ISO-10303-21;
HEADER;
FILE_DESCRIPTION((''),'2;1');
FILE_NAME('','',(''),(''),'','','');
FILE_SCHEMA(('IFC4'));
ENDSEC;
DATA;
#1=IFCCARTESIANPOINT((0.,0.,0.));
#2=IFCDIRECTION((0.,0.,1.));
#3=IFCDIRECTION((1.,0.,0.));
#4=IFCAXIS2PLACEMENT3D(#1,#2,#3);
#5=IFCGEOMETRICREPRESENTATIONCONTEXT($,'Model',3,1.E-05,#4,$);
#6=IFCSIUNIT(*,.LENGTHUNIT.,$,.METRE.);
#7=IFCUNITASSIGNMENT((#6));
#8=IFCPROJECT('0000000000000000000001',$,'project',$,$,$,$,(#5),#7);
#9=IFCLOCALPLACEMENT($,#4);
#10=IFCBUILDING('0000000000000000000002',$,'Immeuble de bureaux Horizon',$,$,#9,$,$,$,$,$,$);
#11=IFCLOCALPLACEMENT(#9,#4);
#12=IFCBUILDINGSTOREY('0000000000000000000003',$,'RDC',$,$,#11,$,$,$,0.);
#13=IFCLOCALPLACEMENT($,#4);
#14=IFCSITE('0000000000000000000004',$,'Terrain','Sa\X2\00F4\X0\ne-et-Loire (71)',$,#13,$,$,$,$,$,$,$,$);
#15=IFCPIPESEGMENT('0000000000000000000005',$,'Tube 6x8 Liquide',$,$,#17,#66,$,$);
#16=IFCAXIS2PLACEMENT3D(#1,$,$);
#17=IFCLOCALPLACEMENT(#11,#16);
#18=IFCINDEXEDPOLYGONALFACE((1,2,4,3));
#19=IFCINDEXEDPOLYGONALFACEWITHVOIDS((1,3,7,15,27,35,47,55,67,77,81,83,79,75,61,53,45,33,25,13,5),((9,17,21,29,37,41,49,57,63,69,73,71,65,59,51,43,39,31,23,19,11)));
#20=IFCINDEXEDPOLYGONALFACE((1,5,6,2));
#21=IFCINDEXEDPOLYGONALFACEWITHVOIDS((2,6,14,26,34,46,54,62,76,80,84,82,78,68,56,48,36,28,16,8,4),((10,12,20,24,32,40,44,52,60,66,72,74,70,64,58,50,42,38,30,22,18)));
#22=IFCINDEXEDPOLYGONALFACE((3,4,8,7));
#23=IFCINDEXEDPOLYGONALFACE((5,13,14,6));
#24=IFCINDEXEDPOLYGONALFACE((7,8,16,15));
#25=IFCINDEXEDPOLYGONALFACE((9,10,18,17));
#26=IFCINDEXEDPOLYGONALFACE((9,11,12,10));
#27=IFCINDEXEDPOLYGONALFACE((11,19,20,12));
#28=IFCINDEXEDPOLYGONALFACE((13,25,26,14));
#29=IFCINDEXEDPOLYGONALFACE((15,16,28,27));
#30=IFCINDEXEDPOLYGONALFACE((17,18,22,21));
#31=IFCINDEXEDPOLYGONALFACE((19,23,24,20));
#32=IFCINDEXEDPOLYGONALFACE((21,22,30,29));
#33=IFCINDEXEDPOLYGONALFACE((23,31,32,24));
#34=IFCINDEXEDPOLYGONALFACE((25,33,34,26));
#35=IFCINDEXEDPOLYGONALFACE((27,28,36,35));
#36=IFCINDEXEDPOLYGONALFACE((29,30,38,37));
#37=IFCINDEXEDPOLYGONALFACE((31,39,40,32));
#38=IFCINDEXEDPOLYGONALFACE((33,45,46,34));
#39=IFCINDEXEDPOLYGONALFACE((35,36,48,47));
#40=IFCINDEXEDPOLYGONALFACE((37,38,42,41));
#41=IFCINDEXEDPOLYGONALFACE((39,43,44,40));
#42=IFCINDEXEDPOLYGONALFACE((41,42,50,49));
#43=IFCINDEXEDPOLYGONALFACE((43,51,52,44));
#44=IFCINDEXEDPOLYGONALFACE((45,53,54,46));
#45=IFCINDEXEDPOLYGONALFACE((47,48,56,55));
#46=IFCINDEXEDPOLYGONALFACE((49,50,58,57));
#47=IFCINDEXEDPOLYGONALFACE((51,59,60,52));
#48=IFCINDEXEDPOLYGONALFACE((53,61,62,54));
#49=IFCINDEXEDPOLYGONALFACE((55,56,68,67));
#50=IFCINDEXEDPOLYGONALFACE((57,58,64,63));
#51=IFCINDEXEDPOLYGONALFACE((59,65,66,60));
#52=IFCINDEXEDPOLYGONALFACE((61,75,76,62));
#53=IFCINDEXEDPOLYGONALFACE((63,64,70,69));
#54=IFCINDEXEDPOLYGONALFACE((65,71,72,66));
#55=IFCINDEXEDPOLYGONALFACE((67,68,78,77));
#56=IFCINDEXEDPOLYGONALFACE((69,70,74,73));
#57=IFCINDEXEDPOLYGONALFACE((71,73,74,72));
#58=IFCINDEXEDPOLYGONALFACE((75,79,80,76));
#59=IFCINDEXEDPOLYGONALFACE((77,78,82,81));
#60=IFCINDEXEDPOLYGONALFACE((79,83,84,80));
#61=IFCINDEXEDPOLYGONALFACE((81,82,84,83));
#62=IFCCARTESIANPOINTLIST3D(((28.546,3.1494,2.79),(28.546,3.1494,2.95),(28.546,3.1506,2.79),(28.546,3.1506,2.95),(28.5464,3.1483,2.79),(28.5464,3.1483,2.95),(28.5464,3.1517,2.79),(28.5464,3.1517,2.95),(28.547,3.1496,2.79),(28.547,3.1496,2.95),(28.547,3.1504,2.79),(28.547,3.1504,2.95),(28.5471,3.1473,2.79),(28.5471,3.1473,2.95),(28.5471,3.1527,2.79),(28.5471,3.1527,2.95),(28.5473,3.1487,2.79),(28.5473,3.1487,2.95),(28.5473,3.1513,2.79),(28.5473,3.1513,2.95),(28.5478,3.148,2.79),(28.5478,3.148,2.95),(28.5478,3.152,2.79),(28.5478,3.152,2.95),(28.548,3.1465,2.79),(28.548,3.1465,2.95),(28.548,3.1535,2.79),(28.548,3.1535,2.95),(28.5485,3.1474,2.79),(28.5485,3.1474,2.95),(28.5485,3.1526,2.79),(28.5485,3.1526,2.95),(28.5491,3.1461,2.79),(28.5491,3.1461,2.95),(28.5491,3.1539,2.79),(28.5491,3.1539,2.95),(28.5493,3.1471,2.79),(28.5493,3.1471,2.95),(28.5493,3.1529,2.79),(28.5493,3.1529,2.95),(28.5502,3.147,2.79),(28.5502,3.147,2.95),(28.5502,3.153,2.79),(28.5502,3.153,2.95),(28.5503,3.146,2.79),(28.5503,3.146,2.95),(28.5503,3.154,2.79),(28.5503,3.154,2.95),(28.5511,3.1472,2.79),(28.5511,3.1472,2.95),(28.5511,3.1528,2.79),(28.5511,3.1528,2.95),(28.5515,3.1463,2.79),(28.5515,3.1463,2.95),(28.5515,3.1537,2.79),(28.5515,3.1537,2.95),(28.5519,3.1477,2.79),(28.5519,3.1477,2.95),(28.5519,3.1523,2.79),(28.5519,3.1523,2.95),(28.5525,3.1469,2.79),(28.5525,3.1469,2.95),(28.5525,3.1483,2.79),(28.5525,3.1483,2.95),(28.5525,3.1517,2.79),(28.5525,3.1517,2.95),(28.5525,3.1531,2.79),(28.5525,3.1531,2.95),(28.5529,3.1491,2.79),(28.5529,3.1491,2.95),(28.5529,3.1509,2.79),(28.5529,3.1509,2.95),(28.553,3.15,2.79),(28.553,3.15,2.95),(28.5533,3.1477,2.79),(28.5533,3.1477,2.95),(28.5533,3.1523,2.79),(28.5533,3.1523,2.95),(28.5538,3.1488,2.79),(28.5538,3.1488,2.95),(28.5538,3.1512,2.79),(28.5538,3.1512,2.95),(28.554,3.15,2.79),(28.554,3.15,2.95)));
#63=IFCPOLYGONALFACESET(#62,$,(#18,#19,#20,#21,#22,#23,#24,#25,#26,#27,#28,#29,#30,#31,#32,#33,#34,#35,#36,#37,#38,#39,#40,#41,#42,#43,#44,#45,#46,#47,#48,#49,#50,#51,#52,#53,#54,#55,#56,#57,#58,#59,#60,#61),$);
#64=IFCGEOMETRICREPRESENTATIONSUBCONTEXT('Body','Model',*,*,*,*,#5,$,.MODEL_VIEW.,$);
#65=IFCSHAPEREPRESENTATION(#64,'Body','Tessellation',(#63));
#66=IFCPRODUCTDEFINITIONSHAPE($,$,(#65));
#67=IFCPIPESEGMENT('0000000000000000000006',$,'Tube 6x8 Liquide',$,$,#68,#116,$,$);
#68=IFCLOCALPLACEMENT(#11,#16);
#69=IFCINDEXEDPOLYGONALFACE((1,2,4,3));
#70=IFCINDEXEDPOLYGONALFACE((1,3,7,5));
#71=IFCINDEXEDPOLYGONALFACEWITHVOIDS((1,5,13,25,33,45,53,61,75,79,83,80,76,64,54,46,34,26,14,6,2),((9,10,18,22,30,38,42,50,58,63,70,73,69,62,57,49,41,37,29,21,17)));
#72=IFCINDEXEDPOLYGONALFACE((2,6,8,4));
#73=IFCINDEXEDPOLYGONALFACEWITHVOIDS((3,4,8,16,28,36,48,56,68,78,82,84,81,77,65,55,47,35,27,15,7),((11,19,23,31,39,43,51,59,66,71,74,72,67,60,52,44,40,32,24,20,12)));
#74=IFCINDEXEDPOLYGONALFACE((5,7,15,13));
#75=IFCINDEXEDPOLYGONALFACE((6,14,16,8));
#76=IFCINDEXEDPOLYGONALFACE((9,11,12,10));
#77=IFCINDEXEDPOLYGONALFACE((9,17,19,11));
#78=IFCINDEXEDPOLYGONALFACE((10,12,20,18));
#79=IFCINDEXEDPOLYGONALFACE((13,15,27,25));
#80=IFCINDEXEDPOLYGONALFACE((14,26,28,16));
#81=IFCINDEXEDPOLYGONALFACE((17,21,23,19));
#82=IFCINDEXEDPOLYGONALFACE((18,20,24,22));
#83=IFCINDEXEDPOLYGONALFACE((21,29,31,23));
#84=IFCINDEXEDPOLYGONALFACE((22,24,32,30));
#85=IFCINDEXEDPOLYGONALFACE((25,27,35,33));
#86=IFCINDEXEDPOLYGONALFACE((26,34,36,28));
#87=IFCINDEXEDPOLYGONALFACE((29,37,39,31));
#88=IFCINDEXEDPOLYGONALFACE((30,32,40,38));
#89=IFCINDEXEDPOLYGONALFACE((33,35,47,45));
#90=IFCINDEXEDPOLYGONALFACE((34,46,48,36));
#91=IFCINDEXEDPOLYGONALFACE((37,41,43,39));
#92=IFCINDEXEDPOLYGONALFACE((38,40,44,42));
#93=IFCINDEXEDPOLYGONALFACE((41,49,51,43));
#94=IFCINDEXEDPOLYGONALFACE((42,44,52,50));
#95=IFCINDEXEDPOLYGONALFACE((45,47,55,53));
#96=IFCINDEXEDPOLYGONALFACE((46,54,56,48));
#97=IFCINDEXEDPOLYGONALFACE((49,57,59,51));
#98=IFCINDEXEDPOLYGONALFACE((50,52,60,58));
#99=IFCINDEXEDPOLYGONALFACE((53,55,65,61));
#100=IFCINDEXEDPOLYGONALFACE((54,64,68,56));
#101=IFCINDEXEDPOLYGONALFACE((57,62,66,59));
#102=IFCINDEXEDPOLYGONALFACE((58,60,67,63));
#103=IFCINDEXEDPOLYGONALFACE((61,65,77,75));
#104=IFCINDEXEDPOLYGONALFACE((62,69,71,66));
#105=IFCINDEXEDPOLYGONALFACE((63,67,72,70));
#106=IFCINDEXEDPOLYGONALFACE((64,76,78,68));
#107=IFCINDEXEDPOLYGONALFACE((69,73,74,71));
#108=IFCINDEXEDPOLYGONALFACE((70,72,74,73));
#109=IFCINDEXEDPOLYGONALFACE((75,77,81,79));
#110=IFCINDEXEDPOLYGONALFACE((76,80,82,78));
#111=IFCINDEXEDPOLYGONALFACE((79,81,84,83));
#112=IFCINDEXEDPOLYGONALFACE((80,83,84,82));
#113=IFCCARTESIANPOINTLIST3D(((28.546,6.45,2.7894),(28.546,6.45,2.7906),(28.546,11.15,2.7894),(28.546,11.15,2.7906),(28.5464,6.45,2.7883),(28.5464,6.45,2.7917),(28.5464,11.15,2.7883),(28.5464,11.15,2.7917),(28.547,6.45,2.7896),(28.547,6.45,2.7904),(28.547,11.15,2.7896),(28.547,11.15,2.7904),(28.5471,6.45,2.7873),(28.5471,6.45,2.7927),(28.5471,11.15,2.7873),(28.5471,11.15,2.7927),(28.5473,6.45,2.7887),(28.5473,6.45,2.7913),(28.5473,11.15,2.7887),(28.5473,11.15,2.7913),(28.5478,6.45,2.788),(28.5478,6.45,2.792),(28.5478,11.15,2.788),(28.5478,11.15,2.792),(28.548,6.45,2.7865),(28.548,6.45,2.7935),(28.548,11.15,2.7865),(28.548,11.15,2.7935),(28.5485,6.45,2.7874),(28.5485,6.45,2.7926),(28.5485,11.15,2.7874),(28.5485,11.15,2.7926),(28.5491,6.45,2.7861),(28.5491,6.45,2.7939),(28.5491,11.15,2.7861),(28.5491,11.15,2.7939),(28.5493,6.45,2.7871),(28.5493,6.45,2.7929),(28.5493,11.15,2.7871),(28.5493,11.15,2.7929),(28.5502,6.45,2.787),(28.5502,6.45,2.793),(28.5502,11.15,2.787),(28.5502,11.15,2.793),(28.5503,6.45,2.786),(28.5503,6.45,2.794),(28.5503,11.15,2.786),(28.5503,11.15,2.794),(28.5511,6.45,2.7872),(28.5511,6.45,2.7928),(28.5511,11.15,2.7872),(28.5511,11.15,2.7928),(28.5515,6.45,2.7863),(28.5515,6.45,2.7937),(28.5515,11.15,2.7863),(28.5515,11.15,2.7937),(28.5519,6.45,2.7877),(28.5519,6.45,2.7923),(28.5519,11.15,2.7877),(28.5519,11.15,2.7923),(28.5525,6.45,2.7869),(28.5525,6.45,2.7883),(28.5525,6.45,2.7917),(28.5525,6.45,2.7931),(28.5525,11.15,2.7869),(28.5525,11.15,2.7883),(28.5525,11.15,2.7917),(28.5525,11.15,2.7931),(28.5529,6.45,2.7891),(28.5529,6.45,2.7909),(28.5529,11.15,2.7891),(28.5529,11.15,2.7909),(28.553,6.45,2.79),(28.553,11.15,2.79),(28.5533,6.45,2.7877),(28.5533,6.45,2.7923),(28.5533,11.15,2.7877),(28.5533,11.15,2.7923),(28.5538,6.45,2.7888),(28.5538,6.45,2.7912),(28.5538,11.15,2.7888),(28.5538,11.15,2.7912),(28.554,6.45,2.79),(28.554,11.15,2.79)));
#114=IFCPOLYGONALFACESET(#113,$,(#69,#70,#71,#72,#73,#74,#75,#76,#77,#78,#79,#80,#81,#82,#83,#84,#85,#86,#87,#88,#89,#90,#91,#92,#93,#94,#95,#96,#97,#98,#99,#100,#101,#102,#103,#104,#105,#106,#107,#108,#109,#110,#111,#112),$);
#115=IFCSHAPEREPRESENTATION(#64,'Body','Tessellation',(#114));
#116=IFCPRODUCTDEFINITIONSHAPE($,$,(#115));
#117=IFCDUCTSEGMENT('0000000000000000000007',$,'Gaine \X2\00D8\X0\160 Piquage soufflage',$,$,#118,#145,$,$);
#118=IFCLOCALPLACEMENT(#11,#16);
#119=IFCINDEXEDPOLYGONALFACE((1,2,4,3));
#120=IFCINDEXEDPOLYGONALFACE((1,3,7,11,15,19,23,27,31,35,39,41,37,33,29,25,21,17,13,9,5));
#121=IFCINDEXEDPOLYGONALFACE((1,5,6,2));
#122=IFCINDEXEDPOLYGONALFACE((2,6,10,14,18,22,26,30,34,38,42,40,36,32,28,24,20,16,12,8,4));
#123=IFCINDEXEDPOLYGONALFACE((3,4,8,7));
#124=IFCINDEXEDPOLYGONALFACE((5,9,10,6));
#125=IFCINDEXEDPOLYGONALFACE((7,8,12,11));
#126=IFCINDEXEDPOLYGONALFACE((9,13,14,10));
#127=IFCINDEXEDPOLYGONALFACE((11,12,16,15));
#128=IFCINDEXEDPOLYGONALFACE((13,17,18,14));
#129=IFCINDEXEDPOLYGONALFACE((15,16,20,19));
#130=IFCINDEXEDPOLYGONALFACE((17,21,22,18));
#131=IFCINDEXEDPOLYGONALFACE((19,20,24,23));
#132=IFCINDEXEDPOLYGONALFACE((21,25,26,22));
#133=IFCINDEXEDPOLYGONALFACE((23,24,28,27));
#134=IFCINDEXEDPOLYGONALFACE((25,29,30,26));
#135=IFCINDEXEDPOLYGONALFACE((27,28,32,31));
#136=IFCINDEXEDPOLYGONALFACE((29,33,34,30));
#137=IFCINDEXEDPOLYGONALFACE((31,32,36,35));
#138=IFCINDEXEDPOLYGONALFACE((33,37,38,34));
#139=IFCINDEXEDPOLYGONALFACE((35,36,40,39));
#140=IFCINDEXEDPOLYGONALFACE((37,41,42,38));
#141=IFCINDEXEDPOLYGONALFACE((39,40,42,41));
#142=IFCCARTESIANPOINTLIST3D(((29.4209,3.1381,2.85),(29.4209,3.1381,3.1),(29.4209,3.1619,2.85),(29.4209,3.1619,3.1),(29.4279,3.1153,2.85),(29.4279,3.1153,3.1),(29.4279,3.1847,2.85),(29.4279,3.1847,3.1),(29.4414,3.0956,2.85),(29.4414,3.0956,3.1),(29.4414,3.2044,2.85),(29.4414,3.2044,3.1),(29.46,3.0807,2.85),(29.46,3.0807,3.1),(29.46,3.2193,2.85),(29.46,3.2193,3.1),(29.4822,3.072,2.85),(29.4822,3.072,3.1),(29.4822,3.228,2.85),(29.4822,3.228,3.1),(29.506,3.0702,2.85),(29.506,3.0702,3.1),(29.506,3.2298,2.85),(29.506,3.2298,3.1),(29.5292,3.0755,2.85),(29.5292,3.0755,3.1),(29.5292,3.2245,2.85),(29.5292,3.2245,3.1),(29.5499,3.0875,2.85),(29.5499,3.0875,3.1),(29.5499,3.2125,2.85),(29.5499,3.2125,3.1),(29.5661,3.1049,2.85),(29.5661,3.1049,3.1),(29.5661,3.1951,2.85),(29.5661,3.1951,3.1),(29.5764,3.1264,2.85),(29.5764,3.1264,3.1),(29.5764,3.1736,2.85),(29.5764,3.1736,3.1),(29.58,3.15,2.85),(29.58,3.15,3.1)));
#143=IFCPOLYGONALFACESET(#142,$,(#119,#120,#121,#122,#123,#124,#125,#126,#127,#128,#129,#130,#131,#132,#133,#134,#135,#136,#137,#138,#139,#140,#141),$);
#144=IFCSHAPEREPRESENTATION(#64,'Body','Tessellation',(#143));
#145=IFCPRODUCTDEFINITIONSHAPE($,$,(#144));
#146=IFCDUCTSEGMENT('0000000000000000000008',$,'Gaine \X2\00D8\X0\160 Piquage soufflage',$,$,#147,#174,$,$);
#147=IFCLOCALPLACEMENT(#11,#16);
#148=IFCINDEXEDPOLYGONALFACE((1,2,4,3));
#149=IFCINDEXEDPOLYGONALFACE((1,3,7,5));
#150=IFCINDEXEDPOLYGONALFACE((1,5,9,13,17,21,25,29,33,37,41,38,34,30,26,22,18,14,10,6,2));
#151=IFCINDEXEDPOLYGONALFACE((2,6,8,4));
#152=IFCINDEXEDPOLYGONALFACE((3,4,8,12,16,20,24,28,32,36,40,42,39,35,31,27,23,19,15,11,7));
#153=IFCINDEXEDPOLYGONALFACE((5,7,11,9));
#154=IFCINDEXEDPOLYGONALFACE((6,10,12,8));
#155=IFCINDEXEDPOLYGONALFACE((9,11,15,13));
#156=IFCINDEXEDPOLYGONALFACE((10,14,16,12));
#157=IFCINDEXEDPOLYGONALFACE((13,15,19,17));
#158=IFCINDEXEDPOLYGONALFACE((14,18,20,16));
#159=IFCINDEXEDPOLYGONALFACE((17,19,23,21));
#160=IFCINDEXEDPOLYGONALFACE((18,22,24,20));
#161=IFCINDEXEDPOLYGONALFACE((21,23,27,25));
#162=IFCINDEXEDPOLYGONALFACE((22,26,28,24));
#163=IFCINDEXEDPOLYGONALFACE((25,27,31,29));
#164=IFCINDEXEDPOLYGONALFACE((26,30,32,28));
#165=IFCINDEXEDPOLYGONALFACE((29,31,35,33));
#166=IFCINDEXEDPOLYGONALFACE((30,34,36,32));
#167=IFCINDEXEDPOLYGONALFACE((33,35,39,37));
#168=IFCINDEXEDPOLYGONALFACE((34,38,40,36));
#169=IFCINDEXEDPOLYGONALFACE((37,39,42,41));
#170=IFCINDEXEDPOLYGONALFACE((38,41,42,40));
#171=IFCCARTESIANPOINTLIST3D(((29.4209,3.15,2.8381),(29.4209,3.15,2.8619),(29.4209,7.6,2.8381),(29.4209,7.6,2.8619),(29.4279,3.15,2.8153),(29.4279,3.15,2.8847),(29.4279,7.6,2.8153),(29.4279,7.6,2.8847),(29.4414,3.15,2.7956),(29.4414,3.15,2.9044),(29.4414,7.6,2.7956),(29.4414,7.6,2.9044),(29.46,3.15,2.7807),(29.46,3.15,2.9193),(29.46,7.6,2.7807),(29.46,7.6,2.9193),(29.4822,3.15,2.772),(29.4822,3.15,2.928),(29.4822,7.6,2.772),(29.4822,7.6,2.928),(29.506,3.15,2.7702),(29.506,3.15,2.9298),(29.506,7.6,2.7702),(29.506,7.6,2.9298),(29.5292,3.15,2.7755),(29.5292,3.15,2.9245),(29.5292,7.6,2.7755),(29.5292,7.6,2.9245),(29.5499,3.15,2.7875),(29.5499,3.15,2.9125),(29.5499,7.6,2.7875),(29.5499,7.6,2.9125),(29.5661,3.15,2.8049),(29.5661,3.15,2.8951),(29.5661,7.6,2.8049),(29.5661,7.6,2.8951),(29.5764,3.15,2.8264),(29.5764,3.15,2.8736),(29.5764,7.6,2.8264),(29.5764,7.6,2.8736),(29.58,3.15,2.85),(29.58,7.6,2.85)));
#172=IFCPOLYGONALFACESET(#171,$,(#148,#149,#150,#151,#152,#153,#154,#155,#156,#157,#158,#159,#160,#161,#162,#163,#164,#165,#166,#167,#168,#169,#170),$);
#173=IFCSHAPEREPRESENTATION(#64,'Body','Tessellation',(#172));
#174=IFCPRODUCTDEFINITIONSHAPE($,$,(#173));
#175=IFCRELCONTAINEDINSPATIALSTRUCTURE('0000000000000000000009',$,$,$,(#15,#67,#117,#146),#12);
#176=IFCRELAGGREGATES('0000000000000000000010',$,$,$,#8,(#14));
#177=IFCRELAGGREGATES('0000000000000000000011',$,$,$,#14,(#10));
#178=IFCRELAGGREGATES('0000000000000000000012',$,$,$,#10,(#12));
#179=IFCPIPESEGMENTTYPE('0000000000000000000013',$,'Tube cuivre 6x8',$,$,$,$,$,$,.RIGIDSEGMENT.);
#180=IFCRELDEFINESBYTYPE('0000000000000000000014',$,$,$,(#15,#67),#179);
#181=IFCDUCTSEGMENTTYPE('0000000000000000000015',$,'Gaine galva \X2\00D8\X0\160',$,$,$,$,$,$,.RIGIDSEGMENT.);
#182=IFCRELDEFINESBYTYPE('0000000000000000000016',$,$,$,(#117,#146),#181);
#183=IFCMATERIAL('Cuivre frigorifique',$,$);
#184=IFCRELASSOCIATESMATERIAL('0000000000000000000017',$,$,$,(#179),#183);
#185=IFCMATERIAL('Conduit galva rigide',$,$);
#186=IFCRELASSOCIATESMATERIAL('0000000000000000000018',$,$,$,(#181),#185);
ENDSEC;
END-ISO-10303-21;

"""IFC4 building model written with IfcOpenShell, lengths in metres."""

from ifc_helpers import new_model, si_unit, frame, origin_with_axes, place, context, subcontext, project, spatial, circle, hollow_circle, extrude, material, type_object, element, save


model = new_model("IFC4")

# Units and contexts
model_context = context("Model", 3, precision=1e-05, world=origin_with_axes())
body_context = subcontext(model_context, "Body", "Model", "MODEL_VIEW")
ifc_project = project(units=[si_unit("LENGTHUNIT", "METRE")], contexts=[model_context])

# Site, building, storey
site_placement = place(None, origin_with_axes())
site = spatial("IfcSite", under=ifc_project, at=site_placement, Name="Terrain", Description="Saône-et-Loire (71)")
building_placement = place(None, origin_with_axes())
building = spatial("IfcBuilding", under=site, at=building_placement, Name="Immeuble de bureaux Horizon")
storey_placement = place(building_placement, origin_with_axes())
storey = spatial("IfcBuildingStorey", under=building, at=storey_placement, Name="RDC", Elevation=0.0)

# Shared definitions
ifc_material_1 = material(Name="Cuivre frigorifique")

# Pipe segments
pipe_segment_type_1 = type_object("IfcPipeSegmentType", Name="Tube cuivre 6x8", PredefinedType="RIGIDSEGMENT", material=ifc_material_1)
pipe_segment_1_placement = place(storey_placement, frame((28.55, 3.15, 2.79), z_axis=(0.0, 0.0, 1.0), x_axis=(1.0, 0.0, 0.0)))
element("IfcPipeSegment", 1, at=pipe_segment_1_placement, inside=storey, type_object=pipe_segment_type_1, Name="Tube 6x8 Liquide", context=body_context, shape_type="SweptSolid", body=[
    extrude(hollow_circle(Radius=0.004, WallThickness=0.001), origin_with_axes(), (0.0, 0.0, 1.0), 0.16),
])
pipe_segment_2_placement = place(storey_placement, frame((28.55, 6.45, 2.79), z_axis=(0.0, 1.0, 0.0), x_axis=(1.0, 0.0, 0.0)))
element("IfcPipeSegment", 2, at=pipe_segment_2_placement, inside=storey, type_object=pipe_segment_type_1, Name="Tube 6x8 Liquide", context=body_context, shape_type="SweptSolid", body=[
    extrude(hollow_circle(Radius=0.004, WallThickness=0.001), origin_with_axes(), (0.0, 0.0, 1.0), 4.7),
])

# Duct segments
ifc_material_2 = material(Name="Conduit galva rigide")
duct_segment_type_1 = type_object("IfcDuctSegmentType", Name="Gaine galva Ø160", PredefinedType="RIGIDSEGMENT", material=ifc_material_2)
duct_segment_1_placement = place(storey_placement, frame((29.5, 3.15, 3.1), z_axis=(0.0, 0.0, -1.0), x_axis=(1.0, 0.0, 0.0)))
element("IfcDuctSegment", 3, at=duct_segment_1_placement, inside=storey, type_object=duct_segment_type_1, Name="Gaine Ø160 Piquage soufflage", context=body_context, shape_type="SweptSolid", body=[
    extrude(circle(Radius=0.08), origin_with_axes(), (0.0, 0.0, 1.0), 0.25),
])
duct_segment_2_placement = place(storey_placement, frame((29.5, 3.15, 2.85), z_axis=(0.0, 1.0, 0.0), x_axis=(1.0, 0.0, 0.0)))
element("IfcDuctSegment", 4, at=duct_segment_2_placement, inside=storey, type_object=duct_segment_type_1, Name="Gaine Ø160 Piquage soufflage", context=body_context, shape_type="SweptSolid", body=[
    extrude(circle(Radius=0.08), origin_with_axes(), (0.0, 0.0, 1.0), 4.45),
])

save(model, "model.ifc")
